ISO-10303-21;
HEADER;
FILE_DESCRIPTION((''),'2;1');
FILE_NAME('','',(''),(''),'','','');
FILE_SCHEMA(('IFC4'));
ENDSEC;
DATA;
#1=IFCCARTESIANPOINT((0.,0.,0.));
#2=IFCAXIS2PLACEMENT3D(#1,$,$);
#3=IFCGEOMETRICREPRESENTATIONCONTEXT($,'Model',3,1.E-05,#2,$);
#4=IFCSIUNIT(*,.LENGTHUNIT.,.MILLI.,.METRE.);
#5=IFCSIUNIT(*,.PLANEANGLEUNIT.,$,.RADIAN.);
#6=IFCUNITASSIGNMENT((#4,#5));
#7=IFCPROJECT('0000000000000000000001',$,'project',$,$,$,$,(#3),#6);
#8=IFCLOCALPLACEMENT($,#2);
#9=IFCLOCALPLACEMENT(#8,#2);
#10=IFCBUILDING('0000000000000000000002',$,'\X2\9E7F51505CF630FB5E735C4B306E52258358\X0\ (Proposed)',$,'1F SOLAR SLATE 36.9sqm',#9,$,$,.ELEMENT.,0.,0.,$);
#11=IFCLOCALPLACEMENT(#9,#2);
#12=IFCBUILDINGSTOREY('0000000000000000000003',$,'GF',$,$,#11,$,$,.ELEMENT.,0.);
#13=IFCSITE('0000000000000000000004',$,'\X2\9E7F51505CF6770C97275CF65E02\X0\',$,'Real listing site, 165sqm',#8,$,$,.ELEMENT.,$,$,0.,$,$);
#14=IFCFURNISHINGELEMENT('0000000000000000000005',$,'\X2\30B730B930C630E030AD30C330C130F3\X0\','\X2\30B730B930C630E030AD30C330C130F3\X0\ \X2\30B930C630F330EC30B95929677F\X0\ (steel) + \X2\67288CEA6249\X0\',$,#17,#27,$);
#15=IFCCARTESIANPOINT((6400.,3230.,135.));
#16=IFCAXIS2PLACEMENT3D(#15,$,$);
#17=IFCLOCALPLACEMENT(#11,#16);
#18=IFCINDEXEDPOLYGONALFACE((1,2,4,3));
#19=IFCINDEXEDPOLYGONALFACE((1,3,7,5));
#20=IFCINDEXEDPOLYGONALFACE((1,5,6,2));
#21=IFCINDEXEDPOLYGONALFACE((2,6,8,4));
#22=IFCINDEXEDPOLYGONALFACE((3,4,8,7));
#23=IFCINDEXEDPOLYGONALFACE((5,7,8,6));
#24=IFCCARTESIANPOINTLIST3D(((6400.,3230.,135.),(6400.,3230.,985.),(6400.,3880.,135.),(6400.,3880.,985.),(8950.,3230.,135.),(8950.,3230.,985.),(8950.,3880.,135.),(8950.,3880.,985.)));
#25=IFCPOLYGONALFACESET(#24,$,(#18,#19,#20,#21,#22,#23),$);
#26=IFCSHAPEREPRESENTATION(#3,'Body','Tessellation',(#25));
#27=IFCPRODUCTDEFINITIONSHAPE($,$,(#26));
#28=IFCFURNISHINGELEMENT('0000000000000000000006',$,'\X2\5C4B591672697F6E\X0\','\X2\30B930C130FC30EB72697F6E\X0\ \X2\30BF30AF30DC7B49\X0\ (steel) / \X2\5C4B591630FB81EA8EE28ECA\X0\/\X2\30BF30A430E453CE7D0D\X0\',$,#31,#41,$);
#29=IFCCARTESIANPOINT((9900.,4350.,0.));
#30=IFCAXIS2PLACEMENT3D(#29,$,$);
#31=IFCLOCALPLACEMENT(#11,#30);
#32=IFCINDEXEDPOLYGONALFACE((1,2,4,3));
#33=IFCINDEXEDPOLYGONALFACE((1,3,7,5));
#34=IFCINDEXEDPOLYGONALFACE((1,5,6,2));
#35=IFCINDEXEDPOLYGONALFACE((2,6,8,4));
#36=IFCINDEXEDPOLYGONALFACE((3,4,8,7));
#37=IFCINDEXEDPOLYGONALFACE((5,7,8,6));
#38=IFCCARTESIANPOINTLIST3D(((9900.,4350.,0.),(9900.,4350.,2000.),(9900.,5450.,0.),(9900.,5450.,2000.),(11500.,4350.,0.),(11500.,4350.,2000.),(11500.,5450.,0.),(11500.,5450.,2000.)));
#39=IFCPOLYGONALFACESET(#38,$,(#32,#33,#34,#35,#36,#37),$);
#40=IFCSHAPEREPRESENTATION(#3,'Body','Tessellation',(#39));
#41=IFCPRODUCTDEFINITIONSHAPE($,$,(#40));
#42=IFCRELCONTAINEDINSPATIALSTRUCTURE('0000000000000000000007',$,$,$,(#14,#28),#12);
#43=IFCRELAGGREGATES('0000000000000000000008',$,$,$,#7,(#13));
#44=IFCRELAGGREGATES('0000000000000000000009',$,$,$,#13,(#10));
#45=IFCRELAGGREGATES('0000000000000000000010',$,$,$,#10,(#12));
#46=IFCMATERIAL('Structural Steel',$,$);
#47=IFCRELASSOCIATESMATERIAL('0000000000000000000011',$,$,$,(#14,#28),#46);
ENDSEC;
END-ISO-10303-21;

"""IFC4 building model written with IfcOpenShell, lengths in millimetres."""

from ifc_helpers import new_model, si_unit, frame, frame_2d, origin, place, context, project, spatial, rectangle, extrude, material, element, save


model = new_model("IFC4")

# Units and contexts
model_context = context("Model", 3, precision=1e-05, world=origin())
ifc_project = project(units=[si_unit("LENGTHUNIT", "METRE", prefix="MILLI"), si_unit("PLANEANGLEUNIT", "RADIAN")], contexts=[model_context])

# Site, building, storey
site_placement = place(None, origin())
site = spatial("IfcSite", under=ifc_project, at=site_placement, Name="鹿児島県霧島市", ObjectType="Real listing site, 165sqm", CompositionType="ELEMENT", RefElevation=0.0)
building_placement = place(site_placement, origin())
building = spatial("IfcBuilding", under=site, at=building_placement, Name="鹿児島・平屋の別荘 (Proposed)", ObjectType="1F SOLAR SLATE 36.9sqm", CompositionType="ELEMENT", ElevationOfRefHeight=0.0, ElevationOfTerrain=0.0)
storey_placement = place(building_placement, origin())
storey = spatial("IfcBuildingStorey", under=building, at=storey_placement, Name="GF", CompositionType="ELEMENT", Elevation=0.0)

# Shared definitions
ifc_material_1 = material(Name="Structural Steel")

# Furnishing elements
furnishing_1_placement = place(storey_placement, frame((6400.0, 3230.0, 135.0)))
element("IfcFurnishingElement", 1, at=furnishing_1_placement, inside=storey, material=ifc_material_1, Name="システムキッチン", Description="システムキッチン ステンレス天板 (steel) + 木質扉", context=model_context, shape_type="SweptSolid", body=[
    extrude(rectangle(XDim=2550.0, YDim=650.0, at=frame_2d((1275.0, 325.0))), frame((6400.0, 3230.0, 135.0)), (0.0, 0.0, 1.0), 850.0),
])
furnishing_2_placement = place(storey_placement, frame((9900.0, 4350.0, 0.0)))
element("IfcFurnishingElement", 2, at=furnishing_2_placement, inside=storey, material=ifc_material_1, Name="屋外物置", Description="スチール物置 タクボ等 (steel) / 屋外・自転車/タイヤ収納", context=model_context, shape_type="SweptSolid", body=[
    extrude(rectangle(XDim=1600.0, YDim=1100.0, at=frame_2d((800.0, 550.0))), frame((9900.0, 4350.0, 0.0)), (0.0, 0.0, 1.0), 2000.0),
])

save(model, "model.ifc")
